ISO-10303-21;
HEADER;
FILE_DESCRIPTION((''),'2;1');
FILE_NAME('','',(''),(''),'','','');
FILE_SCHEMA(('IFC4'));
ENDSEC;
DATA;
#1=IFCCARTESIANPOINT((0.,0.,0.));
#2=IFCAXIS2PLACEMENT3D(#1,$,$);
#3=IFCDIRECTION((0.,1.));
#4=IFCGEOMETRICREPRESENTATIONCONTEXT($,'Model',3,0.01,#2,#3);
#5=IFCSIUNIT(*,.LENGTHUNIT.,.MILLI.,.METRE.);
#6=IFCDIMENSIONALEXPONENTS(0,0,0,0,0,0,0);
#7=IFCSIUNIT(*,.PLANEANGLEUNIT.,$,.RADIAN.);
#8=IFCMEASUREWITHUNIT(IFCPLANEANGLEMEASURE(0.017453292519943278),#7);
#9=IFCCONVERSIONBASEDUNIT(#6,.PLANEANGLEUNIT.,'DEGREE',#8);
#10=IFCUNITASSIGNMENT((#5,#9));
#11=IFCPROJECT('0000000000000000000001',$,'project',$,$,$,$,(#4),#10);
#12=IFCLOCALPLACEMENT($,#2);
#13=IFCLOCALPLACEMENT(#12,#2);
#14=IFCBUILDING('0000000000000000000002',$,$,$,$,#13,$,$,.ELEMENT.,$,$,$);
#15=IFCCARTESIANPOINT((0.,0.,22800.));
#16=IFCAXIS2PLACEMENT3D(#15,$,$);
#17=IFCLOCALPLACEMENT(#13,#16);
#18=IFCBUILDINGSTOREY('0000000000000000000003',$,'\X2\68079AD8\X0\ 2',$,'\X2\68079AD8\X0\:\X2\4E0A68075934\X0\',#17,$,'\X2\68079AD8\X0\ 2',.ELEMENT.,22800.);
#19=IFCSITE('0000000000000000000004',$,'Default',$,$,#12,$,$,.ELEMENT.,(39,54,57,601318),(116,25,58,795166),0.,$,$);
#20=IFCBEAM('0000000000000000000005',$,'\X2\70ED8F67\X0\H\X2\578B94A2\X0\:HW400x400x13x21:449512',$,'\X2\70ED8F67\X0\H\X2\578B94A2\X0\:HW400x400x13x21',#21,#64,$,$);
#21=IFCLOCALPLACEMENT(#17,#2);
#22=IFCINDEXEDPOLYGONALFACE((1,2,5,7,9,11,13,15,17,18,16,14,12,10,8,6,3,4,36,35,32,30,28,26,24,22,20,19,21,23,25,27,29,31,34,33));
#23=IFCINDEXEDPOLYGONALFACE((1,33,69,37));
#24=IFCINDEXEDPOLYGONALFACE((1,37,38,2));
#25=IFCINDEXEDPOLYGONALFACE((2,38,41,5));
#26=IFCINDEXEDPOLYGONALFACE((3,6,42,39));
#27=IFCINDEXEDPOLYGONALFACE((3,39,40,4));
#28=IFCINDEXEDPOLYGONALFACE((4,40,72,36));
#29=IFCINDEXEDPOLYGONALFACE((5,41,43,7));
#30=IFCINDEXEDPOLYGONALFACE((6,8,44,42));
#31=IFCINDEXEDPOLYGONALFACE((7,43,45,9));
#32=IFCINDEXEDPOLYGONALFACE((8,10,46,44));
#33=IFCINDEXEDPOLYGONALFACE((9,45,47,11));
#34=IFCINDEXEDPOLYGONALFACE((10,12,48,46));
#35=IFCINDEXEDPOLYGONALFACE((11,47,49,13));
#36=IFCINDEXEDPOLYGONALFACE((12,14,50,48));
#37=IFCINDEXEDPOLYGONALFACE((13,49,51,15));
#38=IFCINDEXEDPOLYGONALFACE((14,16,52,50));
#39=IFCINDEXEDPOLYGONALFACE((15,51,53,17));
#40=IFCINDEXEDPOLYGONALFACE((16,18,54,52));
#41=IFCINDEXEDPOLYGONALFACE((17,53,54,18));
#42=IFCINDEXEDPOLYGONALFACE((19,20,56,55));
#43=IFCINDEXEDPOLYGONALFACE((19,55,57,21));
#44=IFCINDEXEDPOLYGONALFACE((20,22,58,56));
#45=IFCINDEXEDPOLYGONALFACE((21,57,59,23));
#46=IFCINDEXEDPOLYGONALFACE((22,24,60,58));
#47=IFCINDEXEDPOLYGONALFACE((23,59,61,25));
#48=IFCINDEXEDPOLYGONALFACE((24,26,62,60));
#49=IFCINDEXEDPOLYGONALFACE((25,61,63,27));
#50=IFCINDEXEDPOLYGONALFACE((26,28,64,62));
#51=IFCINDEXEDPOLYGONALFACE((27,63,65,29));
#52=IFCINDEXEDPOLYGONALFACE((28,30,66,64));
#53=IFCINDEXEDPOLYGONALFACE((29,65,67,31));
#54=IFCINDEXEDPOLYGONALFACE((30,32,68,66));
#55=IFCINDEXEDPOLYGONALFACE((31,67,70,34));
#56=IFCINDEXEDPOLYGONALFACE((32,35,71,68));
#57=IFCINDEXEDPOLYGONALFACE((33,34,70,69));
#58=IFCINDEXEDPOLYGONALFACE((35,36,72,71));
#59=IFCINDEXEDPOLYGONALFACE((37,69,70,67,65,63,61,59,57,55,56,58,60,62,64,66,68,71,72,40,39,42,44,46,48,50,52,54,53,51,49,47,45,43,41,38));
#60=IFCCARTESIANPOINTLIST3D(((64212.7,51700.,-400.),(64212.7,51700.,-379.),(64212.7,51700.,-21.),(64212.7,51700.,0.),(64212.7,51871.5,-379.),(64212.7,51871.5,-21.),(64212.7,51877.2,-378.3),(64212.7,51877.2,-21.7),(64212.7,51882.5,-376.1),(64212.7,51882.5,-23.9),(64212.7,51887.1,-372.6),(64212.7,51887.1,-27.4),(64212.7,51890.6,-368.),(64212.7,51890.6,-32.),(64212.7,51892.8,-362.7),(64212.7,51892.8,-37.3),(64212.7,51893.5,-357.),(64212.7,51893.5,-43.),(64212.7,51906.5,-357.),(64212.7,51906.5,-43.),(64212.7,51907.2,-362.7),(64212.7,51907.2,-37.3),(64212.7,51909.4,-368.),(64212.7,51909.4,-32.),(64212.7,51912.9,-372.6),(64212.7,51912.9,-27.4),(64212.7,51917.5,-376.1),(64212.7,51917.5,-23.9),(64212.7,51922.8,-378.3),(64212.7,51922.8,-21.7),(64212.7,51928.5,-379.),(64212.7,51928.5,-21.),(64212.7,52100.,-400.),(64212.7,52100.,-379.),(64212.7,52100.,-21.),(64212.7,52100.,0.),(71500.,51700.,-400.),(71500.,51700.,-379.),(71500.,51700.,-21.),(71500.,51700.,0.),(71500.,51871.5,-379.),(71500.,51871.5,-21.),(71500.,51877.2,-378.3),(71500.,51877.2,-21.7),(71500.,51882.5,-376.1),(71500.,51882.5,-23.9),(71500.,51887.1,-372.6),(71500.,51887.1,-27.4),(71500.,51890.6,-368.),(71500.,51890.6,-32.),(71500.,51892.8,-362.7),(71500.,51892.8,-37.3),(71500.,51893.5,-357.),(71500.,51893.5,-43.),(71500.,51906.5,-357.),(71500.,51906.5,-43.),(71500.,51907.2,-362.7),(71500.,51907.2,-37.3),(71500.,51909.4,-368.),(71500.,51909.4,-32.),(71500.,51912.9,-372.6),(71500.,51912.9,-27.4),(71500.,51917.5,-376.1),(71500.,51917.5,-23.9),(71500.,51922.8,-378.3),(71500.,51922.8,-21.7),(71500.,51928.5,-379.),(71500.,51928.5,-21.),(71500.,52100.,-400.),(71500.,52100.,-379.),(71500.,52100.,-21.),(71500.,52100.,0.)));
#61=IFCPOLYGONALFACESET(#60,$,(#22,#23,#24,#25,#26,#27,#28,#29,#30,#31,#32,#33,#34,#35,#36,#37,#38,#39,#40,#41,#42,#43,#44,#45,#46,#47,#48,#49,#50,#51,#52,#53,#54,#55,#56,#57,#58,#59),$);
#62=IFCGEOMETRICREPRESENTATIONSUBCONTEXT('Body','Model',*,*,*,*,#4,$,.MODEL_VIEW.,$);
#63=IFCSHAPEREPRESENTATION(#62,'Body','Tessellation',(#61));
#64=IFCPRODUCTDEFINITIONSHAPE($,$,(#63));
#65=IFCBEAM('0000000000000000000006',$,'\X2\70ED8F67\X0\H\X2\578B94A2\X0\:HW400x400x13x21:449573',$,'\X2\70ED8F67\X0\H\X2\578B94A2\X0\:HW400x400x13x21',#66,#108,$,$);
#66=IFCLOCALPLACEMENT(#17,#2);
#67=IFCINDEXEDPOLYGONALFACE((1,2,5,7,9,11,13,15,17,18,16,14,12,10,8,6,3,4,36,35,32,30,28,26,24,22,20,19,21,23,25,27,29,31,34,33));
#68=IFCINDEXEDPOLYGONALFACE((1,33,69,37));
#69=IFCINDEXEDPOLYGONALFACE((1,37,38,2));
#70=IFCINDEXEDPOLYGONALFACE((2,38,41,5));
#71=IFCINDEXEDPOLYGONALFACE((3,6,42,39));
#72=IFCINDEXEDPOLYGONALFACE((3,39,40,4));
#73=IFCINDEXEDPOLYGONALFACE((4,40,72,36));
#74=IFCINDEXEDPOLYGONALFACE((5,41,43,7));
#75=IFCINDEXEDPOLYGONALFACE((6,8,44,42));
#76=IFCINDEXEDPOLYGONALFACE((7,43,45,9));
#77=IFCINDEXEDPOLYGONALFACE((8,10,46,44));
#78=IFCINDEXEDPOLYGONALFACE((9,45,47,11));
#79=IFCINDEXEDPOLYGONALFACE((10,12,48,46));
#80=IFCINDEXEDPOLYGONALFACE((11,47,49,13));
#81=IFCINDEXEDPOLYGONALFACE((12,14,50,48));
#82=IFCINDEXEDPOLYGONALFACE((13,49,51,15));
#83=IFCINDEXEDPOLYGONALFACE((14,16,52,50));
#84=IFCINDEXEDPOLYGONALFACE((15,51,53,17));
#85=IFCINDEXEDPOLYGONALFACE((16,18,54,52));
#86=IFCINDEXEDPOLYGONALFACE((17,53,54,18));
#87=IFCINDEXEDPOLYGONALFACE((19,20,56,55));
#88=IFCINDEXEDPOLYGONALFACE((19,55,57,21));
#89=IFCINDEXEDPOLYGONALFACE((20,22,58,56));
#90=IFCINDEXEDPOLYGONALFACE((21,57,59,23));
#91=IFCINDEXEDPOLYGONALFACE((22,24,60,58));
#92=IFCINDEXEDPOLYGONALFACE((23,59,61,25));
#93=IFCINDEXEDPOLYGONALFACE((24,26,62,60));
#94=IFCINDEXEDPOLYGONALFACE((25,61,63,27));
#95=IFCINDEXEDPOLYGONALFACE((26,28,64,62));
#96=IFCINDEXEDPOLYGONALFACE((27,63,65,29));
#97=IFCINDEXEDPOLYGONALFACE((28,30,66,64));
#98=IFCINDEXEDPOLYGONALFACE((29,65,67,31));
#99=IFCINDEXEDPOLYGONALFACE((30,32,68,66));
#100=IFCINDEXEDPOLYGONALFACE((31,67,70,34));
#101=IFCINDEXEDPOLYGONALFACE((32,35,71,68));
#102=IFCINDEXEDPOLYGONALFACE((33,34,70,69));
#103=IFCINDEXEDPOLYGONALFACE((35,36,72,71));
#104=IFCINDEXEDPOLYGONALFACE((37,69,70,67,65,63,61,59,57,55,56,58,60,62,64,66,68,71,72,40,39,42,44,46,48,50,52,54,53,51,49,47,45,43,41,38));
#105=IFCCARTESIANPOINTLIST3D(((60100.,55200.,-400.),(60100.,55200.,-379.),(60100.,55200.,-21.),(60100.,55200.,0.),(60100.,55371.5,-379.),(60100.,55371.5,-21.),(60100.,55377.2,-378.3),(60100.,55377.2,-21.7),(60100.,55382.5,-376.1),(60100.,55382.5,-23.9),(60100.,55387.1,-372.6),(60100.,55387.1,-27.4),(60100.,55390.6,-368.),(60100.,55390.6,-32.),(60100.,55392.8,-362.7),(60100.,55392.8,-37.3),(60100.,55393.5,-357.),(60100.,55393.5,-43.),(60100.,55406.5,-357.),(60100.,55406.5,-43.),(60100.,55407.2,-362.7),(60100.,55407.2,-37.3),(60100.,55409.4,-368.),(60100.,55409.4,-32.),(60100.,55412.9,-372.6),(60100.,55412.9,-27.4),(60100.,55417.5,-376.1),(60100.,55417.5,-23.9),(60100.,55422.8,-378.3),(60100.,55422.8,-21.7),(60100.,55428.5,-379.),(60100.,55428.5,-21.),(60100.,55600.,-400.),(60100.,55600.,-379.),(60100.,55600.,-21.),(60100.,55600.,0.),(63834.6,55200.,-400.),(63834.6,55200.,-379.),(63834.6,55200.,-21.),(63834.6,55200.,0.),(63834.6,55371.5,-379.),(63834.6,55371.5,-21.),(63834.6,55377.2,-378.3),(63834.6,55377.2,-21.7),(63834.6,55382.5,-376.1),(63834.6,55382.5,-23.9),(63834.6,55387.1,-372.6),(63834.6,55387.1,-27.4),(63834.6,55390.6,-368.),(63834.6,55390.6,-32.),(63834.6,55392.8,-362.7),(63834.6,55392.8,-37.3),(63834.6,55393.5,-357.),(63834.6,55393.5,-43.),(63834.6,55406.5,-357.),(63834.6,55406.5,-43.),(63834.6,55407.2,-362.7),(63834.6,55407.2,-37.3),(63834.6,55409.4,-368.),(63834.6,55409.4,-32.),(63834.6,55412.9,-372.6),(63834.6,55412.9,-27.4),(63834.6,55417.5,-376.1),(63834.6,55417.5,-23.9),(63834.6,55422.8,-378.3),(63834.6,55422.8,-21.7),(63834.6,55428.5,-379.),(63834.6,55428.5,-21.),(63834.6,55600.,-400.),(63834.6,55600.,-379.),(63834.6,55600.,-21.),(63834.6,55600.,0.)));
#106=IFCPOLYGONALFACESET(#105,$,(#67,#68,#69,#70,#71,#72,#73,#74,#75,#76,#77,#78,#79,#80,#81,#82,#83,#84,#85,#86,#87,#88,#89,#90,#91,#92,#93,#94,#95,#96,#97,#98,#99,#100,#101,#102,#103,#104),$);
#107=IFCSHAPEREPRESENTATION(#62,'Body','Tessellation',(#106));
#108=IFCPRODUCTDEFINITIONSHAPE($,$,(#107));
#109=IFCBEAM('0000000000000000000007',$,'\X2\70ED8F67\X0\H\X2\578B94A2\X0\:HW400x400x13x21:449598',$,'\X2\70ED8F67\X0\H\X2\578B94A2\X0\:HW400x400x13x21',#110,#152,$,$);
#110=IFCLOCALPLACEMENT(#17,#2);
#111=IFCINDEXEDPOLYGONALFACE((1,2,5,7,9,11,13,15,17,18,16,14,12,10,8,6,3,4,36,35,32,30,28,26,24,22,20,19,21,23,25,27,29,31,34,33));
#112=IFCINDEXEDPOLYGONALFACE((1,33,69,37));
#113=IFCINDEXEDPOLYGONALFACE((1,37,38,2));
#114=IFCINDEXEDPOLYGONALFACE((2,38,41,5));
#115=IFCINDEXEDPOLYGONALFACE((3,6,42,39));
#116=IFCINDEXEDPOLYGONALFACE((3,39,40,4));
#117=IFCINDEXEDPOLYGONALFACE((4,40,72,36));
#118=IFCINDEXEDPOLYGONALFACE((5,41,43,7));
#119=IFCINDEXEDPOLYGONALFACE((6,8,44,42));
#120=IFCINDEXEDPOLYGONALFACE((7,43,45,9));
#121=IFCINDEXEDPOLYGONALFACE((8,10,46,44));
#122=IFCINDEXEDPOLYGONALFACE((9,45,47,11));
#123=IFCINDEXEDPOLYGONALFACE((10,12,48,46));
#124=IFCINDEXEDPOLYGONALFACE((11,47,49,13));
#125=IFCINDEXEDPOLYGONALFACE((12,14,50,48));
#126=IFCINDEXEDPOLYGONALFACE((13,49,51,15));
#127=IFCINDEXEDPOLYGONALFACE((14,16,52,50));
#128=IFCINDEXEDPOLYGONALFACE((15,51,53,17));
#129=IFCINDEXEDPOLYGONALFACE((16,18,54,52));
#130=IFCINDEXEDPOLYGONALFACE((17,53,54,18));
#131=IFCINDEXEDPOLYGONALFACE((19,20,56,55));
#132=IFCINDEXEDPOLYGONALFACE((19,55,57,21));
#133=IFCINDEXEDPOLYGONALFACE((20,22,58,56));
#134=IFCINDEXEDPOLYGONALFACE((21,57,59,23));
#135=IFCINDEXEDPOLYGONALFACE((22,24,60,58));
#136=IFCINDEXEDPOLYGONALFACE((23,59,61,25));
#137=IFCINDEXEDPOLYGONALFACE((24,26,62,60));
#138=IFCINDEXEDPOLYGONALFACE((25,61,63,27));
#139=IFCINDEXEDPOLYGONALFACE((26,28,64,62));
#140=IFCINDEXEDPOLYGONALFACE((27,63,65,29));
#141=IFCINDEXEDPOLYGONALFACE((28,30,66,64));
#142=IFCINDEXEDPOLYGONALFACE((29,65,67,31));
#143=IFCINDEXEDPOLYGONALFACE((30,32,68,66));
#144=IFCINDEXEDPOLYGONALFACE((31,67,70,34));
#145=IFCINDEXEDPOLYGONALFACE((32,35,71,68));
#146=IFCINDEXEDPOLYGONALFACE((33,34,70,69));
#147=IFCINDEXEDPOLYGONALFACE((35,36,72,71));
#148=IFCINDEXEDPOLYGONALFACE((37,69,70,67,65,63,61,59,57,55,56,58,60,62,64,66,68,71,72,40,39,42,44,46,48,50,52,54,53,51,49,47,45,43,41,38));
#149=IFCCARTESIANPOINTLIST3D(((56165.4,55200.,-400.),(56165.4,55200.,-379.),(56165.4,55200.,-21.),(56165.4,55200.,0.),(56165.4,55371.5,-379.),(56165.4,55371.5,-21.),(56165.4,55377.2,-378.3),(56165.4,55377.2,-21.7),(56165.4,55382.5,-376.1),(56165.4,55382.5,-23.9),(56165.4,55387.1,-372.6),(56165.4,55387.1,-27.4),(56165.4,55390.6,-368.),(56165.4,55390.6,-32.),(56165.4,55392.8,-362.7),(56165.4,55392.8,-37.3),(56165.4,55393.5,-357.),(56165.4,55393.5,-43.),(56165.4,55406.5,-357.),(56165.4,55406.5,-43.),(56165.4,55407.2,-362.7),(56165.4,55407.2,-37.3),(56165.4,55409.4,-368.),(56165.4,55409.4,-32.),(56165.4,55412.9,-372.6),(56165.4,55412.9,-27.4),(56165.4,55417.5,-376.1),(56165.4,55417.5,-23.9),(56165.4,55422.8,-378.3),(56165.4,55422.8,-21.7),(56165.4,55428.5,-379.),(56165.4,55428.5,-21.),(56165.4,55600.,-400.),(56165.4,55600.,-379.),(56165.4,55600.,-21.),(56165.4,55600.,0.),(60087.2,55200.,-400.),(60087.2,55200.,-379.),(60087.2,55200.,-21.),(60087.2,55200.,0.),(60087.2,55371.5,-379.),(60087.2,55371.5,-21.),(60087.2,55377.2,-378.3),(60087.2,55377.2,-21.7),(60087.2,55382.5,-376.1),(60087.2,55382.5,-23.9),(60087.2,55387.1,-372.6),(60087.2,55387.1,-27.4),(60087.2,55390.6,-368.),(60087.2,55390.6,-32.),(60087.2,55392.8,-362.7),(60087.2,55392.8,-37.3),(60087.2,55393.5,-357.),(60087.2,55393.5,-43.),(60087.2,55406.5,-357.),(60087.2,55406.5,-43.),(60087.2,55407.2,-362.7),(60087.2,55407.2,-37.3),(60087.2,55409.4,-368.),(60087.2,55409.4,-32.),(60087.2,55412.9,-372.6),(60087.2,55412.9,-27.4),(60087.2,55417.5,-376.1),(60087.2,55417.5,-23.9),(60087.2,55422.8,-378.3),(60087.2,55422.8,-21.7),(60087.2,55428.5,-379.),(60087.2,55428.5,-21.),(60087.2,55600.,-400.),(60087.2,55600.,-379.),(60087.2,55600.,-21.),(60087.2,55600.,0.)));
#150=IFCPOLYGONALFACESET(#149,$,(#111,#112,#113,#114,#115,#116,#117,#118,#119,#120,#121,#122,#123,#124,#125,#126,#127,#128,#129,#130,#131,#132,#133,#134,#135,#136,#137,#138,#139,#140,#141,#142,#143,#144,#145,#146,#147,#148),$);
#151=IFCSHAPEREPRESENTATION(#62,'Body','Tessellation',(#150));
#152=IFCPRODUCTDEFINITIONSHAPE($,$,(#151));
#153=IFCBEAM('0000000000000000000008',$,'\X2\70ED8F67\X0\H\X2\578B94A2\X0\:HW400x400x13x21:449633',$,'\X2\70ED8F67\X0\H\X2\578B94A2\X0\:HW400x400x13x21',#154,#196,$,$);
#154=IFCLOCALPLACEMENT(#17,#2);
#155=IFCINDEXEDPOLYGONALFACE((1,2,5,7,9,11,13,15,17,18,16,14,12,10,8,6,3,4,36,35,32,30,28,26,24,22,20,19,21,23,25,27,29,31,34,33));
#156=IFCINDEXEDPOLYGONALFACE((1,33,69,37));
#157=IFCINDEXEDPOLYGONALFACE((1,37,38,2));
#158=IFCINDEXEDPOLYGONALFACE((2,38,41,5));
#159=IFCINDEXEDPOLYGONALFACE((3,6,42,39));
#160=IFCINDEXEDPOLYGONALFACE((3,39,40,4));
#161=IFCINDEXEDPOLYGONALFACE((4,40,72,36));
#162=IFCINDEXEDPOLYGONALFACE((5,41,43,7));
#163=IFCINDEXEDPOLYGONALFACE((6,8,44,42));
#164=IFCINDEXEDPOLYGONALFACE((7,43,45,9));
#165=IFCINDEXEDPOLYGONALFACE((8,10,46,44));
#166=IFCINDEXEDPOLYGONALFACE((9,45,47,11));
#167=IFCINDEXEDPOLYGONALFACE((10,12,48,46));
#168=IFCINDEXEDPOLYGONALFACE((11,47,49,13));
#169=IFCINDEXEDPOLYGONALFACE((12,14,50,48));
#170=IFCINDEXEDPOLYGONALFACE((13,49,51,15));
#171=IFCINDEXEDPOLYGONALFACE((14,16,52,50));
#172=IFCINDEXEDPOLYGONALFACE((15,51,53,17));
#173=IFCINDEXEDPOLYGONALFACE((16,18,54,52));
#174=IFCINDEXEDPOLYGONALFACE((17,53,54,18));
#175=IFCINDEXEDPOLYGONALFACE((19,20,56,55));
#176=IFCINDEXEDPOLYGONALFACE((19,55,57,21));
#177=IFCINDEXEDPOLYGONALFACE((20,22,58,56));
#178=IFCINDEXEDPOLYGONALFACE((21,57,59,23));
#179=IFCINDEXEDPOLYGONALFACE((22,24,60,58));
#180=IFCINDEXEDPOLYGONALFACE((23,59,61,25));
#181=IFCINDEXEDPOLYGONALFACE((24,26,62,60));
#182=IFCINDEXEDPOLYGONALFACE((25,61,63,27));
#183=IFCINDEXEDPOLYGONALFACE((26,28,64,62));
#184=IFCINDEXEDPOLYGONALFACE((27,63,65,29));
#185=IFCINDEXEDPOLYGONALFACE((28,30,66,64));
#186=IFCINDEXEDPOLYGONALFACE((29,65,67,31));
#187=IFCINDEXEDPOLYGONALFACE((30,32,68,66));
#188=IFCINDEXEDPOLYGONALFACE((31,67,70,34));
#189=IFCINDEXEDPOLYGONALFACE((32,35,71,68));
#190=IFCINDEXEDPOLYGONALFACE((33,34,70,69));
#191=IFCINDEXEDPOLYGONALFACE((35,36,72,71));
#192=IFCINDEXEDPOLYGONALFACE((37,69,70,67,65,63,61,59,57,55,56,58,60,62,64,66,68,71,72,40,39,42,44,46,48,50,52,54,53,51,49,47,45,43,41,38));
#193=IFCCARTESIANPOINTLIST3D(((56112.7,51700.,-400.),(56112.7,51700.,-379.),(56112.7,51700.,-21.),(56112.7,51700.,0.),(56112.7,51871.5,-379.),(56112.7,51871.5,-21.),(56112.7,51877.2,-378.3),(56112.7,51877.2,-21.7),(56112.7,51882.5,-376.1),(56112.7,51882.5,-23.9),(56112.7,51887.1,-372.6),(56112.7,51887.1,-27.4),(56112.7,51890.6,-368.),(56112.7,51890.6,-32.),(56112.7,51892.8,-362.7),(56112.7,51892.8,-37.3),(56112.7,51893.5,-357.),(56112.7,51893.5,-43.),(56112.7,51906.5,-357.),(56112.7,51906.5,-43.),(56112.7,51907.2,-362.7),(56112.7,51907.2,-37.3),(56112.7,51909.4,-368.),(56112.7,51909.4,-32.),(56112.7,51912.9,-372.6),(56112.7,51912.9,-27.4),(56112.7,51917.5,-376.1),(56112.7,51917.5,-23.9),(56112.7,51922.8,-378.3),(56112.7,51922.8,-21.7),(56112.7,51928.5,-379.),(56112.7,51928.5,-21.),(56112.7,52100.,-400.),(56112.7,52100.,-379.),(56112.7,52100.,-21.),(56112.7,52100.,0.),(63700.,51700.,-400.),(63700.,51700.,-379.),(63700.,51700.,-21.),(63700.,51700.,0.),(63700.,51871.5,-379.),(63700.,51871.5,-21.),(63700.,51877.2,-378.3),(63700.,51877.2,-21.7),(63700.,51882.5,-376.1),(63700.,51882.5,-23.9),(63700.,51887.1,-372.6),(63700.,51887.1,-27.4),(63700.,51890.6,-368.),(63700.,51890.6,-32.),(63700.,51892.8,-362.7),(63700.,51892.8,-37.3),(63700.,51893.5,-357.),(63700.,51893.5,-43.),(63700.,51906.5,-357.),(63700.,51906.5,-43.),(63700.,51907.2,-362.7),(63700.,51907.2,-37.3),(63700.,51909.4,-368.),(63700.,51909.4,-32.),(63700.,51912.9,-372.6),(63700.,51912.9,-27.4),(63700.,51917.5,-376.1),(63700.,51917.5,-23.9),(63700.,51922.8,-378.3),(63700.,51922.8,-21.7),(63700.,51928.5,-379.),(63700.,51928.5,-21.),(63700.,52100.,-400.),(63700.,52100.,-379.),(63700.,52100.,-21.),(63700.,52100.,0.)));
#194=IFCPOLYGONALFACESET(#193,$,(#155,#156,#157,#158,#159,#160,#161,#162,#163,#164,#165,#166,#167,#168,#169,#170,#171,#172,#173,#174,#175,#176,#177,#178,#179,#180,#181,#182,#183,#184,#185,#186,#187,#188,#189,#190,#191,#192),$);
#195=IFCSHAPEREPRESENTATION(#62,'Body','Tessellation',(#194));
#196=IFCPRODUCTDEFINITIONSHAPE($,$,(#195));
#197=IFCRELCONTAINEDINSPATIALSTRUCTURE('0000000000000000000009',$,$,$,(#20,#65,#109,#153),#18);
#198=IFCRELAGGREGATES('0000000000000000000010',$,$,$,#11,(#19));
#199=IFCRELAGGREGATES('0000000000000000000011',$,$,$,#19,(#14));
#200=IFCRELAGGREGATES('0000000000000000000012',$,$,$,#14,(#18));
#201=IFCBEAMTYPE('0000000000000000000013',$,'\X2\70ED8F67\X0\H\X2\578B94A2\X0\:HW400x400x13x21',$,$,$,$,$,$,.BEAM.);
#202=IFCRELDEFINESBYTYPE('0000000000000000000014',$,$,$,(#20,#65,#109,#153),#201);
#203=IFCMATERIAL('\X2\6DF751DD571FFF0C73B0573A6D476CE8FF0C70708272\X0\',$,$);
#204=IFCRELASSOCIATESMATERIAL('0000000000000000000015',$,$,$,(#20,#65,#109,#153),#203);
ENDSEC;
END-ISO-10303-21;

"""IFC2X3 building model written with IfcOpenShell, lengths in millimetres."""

from ifc_helpers import new_model, entity, si_unit, converted_unit, direction, frame, frame_2d, origin, place, context, subcontext, project, spatial, i_section, extrude, material, type_object, element, save


model = new_model("IFC2X3")

# Units and contexts
model_context = context("Model", 3, precision=0.01, world=origin(), true_north=direction((0.0, 1.0)))
body_context = subcontext(model_context, "Body", "Model", "MODEL_VIEW")
ifc_project = project(units=[si_unit("LENGTHUNIT", "METRE", prefix="MILLI"), converted_unit("PLANEANGLEUNIT", "DEGREE", entity("IfcPlaneAngleMeasure", 0.017453292519943278), si_unit("PLANEANGLEUNIT", "RADIAN"), dimensions=[0, 0, 0, 0, 0, 0, 0])], contexts=[model_context])

# Site, building, storey
site_placement = place(None, origin())
site = spatial("IfcSite", under=ifc_project, at=site_placement, Name="Default", CompositionType="ELEMENT", RefLatitude=(39, 54, 57, 601318), RefLongitude=(116, 25, 58, 795166), RefElevation=0.0)
building_placement = place(site_placement, origin())
building = spatial("IfcBuilding", under=site, at=building_placement, CompositionType="ELEMENT")
storey_placement = place(building_placement, frame((0.0, 0.0, 22800.0)))
storey = spatial("IfcBuildingStorey", under=building, at=storey_placement, Name="标高 2", ObjectType="标高:上标头", LongName="标高 2", CompositionType="ELEMENT", Elevation=22800.0)

# Beams
ifc_material = material(Name="混凝土，现场浇注，灰色")
beam_type = type_object("IfcBeamType", Name="热轧H型钢:HW400x400x13x21", PredefinedType="BEAM")
beam_1_placement = place(storey_placement, frame((64000.0, 51900.0, 0.0)))
element("IfcBeam", 1, at=beam_1_placement, inside=storey, type_object=beam_type, material=ifc_material, Name="热轧H型钢:HW400x400x13x21:449512", ObjectType="热轧H型钢:HW400x400x13x21", context=body_context, shape_type="SweptSolid", body=[
    extrude(i_section(OverallWidth=400.0, OverallDepth=400.0, WebThickness=13.0, FlangeThickness=21.0, FilletRadius=22.0, at=frame_2d((0.0, 0.0), x_axis=(0.0, 1.0))), frame((212.7, 0.0, -200.0), z_axis=(1.0, 0.0, 0.0), x_axis=(0.0, 0.0, -1.0)), (0.0, 0.0, 1.0), 7287.3),
])
beam_2_placement = place(storey_placement, frame((60100.0, 55400.0, 0.0)))
element("IfcBeam", 2, at=beam_2_placement, inside=storey, type_object=beam_type, material=ifc_material, Name="热轧H型钢:HW400x400x13x21:449573", ObjectType="热轧H型钢:HW400x400x13x21", context=body_context, shape_type="SweptSolid", body=[
    extrude(i_section(OverallWidth=400.0, OverallDepth=400.0, WebThickness=13.0, FlangeThickness=21.0, FilletRadius=22.0, at=frame_2d((0.0, 0.0), x_axis=(0.0, 1.0))), frame((0.0, 0.0, -200.0), z_axis=(1.0, 0.0, 0.0), x_axis=(0.0, 0.0, -1.0)), (0.0, 0.0, 1.0), 3734.6),
])
beam_3_placement = place(storey_placement, frame((55900.0, 55400.0, 0.0)))
element("IfcBeam", 3, at=beam_3_placement, inside=storey, type_object=beam_type, material=ifc_material, Name="热轧H型钢:HW400x400x13x21:449598", ObjectType="热轧H型钢:HW400x400x13x21", context=body_context, shape_type="SweptSolid", body=[
    extrude(i_section(OverallWidth=400.0, OverallDepth=400.0, WebThickness=13.0, FlangeThickness=21.0, FilletRadius=22.0, at=frame_2d((0.0, 0.0), x_axis=(0.0, 1.0))), frame((265.4, 0.0, -200.0), z_axis=(1.0, 0.0, 0.0), x_axis=(0.0, 0.0, -1.0)), (0.0, 0.0, 1.0), 3921.8),
])
beam_4_placement = place(storey_placement, frame((55900.0, 51900.0, 0.0)))
element("IfcBeam", 4, at=beam_4_placement, inside=storey, type_object=beam_type, material=ifc_material, Name="热轧H型钢:HW400x400x13x21:449633", ObjectType="热轧H型钢:HW400x400x13x21", context=body_context, shape_type="SweptSolid", body=[
    extrude(i_section(OverallWidth=400.0, OverallDepth=400.0, WebThickness=13.0, FlangeThickness=21.0, FilletRadius=22.0, at=frame_2d((0.0, 0.0), x_axis=(0.0, 1.0))), frame((212.7, 0.0, -200.0), z_axis=(1.0, 0.0, 0.0), x_axis=(0.0, 0.0, -1.0)), (0.0, 0.0, 1.0), 7587.3),
])

save(model, "model.ifc")
